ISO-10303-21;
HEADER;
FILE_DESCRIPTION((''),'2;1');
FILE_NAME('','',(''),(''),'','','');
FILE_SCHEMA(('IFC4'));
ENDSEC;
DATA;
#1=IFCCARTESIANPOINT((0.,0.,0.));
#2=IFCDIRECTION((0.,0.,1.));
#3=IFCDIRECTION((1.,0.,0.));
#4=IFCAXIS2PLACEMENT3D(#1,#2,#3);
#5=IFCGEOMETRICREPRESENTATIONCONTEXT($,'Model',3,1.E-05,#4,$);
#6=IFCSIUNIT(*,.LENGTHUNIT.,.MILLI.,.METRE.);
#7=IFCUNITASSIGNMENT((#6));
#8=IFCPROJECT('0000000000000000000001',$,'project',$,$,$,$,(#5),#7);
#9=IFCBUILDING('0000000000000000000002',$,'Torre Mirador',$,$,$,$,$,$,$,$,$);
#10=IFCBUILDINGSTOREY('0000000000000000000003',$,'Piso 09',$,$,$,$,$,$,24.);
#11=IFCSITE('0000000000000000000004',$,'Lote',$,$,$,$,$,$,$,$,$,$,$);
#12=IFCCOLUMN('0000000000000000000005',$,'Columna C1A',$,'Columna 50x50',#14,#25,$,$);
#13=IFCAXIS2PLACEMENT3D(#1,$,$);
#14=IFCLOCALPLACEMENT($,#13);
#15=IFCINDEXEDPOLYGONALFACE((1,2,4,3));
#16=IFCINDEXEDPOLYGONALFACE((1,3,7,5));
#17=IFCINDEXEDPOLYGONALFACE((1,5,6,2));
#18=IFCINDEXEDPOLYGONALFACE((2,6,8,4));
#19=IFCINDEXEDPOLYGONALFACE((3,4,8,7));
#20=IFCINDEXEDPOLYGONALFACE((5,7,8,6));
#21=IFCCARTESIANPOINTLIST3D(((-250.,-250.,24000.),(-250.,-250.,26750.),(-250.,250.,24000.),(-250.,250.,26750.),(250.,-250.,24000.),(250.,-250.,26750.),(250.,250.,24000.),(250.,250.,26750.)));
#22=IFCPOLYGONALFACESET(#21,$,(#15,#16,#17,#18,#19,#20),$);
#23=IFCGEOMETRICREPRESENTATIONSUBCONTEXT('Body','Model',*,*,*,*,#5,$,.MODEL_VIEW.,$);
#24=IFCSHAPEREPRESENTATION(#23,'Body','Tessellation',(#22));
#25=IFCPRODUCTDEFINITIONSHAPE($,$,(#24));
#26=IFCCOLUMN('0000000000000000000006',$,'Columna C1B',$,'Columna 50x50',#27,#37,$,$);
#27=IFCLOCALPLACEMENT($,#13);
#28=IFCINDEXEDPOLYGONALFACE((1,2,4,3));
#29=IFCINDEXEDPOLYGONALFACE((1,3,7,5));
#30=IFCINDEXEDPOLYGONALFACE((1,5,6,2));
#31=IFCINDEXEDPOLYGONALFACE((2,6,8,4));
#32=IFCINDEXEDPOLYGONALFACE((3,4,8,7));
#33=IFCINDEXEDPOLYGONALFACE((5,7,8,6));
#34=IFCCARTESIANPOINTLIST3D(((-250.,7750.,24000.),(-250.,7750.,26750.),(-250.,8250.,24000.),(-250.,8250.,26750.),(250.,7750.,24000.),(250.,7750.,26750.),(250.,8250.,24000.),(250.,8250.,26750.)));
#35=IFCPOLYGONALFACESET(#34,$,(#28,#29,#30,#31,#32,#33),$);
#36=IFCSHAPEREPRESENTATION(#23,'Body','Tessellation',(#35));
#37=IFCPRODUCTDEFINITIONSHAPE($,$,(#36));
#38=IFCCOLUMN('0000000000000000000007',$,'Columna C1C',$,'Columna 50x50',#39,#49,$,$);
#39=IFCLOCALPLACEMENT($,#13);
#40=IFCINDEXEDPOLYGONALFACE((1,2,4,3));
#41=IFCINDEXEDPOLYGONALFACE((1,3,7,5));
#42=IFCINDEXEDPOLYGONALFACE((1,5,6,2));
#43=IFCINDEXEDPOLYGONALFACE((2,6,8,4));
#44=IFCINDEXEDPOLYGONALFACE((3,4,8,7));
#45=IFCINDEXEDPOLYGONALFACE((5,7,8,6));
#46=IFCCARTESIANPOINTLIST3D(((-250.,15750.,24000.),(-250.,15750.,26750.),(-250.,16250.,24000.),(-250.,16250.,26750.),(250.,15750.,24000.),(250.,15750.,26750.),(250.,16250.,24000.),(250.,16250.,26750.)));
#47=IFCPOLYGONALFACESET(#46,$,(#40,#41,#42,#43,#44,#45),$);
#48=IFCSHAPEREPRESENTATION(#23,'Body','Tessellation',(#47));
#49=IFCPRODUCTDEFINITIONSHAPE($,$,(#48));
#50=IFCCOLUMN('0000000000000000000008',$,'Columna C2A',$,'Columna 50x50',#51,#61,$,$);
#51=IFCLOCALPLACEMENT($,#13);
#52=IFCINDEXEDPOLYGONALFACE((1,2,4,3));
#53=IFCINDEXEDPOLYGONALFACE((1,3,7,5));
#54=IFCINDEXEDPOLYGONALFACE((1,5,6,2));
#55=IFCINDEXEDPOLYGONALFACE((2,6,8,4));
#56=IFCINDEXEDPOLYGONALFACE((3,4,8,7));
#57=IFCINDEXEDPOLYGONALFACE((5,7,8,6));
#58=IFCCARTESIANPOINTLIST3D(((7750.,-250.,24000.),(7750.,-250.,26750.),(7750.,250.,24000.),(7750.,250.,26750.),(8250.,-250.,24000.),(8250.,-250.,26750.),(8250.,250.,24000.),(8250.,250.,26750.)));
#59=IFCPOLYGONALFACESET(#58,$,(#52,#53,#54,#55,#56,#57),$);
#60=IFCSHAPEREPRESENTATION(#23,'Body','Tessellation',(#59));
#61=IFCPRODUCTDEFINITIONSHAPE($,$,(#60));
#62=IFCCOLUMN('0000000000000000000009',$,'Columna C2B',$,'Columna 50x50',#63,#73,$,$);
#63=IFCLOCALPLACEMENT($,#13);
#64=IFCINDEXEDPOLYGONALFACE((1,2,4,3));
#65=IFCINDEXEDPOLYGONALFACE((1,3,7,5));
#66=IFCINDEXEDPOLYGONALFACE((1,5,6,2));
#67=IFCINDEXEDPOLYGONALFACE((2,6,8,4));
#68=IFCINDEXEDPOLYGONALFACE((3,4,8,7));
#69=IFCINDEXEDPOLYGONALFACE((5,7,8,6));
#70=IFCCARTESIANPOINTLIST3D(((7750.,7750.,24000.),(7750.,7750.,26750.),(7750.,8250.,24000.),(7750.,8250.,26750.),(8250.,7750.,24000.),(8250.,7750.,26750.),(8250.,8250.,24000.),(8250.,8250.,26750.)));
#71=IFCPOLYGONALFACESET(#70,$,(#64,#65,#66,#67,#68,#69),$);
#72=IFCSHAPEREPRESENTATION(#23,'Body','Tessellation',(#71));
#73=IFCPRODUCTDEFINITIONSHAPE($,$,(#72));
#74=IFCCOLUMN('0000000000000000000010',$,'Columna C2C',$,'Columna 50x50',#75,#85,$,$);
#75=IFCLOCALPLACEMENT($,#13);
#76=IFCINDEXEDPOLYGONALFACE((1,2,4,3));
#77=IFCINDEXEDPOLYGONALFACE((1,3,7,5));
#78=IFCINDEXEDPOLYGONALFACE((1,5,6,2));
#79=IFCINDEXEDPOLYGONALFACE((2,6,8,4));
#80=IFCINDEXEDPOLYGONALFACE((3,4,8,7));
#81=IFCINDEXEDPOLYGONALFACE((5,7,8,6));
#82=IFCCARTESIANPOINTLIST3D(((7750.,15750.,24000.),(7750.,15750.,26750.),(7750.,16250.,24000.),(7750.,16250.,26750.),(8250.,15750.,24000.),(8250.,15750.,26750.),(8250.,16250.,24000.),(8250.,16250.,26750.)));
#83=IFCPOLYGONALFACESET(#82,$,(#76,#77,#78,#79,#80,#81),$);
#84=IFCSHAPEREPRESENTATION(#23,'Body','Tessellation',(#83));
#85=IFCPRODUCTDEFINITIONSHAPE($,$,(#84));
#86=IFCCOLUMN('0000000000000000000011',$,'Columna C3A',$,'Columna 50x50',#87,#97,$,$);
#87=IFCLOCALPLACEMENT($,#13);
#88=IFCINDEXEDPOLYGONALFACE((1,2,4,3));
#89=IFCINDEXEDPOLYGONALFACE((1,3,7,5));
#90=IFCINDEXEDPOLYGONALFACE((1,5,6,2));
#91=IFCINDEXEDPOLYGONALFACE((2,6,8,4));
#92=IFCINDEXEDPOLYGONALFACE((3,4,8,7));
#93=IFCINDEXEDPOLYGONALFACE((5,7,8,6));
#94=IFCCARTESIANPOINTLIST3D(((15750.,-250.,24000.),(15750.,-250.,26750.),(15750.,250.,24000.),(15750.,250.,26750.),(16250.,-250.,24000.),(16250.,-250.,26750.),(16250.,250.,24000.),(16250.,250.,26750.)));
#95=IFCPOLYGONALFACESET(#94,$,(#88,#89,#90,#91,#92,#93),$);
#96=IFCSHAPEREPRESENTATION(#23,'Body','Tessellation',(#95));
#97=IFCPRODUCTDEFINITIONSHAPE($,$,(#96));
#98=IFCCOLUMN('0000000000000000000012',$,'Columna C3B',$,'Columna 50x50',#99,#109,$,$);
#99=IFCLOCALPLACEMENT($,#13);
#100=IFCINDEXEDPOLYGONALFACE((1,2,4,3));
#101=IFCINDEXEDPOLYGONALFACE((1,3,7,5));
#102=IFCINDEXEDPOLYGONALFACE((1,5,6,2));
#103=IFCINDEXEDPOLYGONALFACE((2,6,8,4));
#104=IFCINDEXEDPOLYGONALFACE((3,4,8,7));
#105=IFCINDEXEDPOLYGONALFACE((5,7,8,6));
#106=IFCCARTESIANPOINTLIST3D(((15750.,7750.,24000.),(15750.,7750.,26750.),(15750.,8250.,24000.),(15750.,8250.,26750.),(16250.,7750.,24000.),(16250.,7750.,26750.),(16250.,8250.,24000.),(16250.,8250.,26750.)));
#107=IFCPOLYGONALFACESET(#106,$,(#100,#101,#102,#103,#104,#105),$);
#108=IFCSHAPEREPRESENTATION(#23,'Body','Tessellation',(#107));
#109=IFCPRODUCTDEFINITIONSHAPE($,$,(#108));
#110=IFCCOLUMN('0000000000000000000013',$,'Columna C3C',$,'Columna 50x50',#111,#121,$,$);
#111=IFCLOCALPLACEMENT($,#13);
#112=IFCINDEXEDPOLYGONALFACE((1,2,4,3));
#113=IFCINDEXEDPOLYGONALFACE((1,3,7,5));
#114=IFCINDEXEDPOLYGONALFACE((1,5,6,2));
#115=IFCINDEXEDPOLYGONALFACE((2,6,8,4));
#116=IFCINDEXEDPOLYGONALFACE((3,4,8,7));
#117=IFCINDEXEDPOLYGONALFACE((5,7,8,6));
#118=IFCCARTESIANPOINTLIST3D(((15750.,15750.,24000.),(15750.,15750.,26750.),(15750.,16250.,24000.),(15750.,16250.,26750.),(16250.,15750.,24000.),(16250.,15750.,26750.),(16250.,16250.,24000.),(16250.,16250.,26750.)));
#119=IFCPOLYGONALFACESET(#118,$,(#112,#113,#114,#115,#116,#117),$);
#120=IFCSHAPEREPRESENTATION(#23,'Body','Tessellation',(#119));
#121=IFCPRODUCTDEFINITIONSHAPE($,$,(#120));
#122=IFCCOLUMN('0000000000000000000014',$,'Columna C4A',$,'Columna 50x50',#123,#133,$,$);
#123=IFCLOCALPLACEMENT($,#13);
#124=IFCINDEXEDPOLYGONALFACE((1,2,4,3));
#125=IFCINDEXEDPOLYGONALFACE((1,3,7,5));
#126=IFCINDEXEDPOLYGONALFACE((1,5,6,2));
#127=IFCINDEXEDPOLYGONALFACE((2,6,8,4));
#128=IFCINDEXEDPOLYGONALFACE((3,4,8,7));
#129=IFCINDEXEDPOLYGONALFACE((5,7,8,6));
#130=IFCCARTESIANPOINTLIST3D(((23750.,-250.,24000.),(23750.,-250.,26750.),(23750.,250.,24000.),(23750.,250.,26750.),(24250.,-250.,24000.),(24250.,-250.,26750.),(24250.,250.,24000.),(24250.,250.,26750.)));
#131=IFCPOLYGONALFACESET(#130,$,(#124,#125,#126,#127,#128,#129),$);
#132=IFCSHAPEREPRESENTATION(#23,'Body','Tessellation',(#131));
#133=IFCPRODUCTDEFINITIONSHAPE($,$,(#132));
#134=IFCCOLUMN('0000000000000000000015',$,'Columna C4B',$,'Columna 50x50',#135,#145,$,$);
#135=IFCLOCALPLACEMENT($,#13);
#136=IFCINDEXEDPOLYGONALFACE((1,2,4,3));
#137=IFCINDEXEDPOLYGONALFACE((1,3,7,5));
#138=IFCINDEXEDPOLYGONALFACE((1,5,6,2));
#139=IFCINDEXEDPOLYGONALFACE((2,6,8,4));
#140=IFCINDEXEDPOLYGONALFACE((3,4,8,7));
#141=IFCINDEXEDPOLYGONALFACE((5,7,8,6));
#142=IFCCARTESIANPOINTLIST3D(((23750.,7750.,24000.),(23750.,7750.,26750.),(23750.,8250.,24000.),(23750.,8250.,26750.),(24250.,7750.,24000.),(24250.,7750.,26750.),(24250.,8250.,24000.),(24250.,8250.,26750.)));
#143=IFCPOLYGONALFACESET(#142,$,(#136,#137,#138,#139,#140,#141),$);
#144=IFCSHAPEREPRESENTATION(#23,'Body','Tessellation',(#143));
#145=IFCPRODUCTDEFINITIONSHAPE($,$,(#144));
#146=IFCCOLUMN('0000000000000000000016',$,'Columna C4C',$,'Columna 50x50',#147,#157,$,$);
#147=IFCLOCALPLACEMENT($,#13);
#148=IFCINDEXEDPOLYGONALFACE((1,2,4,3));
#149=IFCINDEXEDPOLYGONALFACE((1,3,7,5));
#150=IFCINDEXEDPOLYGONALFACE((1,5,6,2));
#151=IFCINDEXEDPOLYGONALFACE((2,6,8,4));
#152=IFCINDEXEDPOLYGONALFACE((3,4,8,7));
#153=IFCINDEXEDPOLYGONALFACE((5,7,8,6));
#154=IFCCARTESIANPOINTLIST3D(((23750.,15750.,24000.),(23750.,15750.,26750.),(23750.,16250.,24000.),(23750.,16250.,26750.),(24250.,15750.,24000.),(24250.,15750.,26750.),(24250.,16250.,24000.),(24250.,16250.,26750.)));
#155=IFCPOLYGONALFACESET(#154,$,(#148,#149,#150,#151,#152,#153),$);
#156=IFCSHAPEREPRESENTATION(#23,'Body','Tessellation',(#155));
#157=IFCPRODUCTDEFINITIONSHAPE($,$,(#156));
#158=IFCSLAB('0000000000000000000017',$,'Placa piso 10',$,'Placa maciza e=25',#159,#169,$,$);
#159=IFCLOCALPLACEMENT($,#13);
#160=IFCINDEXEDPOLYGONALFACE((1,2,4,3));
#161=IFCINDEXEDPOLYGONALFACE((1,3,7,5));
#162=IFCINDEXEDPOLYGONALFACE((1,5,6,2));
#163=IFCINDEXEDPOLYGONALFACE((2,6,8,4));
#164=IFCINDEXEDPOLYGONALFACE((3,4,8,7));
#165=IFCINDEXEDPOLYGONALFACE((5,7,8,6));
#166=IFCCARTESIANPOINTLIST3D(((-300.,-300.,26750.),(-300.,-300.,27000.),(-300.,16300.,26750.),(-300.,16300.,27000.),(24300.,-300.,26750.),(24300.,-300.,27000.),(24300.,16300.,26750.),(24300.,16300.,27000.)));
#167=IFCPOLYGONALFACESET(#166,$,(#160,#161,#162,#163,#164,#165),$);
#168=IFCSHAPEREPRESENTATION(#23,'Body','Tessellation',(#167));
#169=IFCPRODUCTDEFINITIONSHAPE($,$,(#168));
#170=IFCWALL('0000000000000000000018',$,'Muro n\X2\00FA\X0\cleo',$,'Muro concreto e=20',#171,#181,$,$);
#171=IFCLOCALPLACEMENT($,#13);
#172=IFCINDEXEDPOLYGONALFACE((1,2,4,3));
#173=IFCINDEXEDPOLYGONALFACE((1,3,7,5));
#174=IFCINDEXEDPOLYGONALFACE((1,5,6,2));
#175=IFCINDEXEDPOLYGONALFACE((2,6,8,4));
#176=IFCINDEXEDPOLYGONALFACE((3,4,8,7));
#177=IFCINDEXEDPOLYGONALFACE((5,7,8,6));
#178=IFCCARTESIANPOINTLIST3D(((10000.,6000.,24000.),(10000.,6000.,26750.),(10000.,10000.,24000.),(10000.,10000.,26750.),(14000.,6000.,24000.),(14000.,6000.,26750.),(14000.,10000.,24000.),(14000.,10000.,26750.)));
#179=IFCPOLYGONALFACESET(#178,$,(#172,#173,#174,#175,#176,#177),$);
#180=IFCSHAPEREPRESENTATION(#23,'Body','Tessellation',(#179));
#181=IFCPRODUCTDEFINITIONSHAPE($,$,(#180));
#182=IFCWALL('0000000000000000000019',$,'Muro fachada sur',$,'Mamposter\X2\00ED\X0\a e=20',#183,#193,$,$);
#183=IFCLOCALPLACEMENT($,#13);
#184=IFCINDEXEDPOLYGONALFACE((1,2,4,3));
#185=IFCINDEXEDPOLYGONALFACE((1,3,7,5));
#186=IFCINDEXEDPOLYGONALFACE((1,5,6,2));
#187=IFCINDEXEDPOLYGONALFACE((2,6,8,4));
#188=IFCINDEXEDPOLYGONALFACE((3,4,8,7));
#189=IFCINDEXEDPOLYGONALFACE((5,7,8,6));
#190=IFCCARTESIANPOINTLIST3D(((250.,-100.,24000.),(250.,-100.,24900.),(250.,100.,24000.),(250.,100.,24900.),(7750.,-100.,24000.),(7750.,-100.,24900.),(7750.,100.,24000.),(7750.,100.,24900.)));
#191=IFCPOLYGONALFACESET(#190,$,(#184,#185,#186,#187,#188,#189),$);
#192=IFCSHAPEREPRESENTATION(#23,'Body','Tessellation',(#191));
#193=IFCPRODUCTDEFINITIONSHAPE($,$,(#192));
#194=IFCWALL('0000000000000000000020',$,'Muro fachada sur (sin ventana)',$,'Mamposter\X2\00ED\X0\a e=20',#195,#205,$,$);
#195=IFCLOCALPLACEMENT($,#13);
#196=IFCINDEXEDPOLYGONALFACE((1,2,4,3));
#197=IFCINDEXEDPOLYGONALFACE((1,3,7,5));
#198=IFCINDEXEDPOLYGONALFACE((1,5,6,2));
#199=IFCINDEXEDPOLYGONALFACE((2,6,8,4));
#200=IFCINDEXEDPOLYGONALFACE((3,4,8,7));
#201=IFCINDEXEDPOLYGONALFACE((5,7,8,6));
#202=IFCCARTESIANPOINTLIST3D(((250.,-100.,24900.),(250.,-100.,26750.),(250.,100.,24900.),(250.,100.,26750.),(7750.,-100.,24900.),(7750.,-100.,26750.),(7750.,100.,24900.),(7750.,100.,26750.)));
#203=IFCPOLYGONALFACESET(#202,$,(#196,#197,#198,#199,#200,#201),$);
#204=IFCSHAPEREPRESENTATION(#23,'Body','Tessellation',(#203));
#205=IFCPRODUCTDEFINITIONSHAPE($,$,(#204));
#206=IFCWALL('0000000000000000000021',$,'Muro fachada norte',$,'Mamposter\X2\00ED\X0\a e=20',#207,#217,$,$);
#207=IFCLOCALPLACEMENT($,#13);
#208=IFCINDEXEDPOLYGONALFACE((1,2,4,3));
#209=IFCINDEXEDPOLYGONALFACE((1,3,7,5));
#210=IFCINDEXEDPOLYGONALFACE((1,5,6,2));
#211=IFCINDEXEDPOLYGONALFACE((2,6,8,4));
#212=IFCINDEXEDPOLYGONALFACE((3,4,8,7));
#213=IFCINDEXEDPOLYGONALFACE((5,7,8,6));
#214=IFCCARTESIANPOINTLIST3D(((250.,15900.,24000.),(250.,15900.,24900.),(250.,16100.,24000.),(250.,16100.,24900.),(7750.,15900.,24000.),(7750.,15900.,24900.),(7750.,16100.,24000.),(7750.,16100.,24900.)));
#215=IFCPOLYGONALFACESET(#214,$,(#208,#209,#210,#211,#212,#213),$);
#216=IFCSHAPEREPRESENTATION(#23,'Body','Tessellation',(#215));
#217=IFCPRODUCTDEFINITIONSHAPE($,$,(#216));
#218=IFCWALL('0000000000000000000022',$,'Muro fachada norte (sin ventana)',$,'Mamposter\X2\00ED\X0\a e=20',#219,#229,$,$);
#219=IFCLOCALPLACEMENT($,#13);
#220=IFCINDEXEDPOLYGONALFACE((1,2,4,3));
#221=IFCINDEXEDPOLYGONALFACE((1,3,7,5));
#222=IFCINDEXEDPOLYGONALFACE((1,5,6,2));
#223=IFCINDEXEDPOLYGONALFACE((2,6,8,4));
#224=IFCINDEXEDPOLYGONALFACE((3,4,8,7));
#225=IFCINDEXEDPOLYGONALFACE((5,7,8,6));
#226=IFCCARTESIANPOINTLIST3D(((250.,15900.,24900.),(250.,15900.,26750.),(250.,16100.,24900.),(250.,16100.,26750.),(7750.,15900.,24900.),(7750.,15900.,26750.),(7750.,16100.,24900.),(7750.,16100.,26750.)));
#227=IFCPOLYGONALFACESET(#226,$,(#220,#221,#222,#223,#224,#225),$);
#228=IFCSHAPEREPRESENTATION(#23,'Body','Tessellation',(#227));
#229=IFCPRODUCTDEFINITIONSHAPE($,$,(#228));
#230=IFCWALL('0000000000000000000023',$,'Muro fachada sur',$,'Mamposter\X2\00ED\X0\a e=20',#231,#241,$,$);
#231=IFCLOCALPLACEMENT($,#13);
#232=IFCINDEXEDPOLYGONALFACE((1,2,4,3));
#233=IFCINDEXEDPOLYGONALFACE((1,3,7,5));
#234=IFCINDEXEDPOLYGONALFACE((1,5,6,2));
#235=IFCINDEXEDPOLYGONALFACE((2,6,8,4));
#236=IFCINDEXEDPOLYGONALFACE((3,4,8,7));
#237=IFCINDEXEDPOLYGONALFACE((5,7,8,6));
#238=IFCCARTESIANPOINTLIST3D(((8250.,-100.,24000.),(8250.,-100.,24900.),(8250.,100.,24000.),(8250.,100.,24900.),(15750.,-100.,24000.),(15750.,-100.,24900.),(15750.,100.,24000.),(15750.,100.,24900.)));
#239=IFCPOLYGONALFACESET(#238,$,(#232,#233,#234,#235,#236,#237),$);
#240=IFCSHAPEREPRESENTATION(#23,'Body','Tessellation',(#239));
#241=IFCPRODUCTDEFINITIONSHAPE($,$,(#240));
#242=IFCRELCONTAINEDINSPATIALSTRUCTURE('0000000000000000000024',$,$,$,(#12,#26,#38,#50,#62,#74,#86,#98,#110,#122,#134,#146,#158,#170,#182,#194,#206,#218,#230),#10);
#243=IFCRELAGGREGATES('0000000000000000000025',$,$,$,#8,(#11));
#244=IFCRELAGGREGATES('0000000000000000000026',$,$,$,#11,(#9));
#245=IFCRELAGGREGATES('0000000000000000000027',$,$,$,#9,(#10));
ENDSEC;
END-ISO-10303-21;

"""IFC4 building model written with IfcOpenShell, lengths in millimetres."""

from ifc_helpers import new_model, si_unit, frame, origin_with_axes, place, context, subcontext, project, spatial, indexed_curve, outline, extrude, element, save


model = new_model("IFC4")

# Units and contexts
model_context = context("Model", 3, precision=1e-05, world=origin_with_axes())
body_context = subcontext(model_context, "Body", "Model", "MODEL_VIEW")
ifc_project = project(units=[si_unit("LENGTHUNIT", "METRE", prefix="MILLI")], contexts=[model_context])

# Site, building, storey
site = spatial("IfcSite", under=ifc_project, Name="Lote")
building = spatial("IfcBuilding", under=site, Name="Torre Mirador")
storey = spatial("IfcBuildingStorey", under=building, Name="Piso 09", Elevation=24.0)

# Columns
for number, where, z_axis, x_axis, name in (
    (1, (-250.0, -250.0, 24000.0), (0.0, 0.0, 1.0), (1.0, 0.0, 0.0), "Columna C1A"),
    (2, (-250.0, 7750.0, 24000.0), (0.0, 0.0, 1.0), (1.0, 0.0, 0.0), "Columna C1B"),
    (3, (-250.0, 15750.0, 24000.0), (0.0, 0.0, 1.0), (1.0, 0.0, 0.0), "Columna C1C"),
    (4, (7750.0, -250.0, 24000.0), (0.0, 0.0, 1.0), (1.0, 0.0, 0.0), "Columna C2A"),
    (5, (7750.0, 7750.0, 24000.0), (0.0, 0.0, 1.0), (1.0, 0.0, 0.0), "Columna C2B"),
    (6, (7750.0, 15750.0, 24000.0), (0.0, 0.0, 1.0), (1.0, 0.0, 0.0), "Columna C2C"),
    (7, (15750.0, -250.0, 24000.0), (0.0, 0.0, 1.0), (1.0, 0.0, 0.0), "Columna C3A"),
    (8, (15750.0, 7750.0, 24000.0), (0.0, 0.0, 1.0), (1.0, 0.0, 0.0), "Columna C3B"),
    (9, (15750.0, 15750.0, 24000.0), (0.0, 0.0, 1.0), (1.0, 0.0, 0.0), "Columna C3C"),
    (10, (23750.0, -250.0, 24000.0), (0.0, 0.0, 1.0), (1.0, 0.0, 0.0), "Columna C4A"),
    (11, (23750.0, 7750.0, 24000.0), (0.0, 0.0, 1.0), (1.0, 0.0, 0.0), "Columna C4B"),
    (12, (23750.0, 15750.0, 24000.0), (0.0, 0.0, 1.0), (1.0, 0.0, 0.0), "Columna C4C"),
):
    element("IfcColumn", number, at=place(None, frame(where, z_axis=z_axis, x_axis=x_axis)), inside=storey, Name=name, ObjectType="Columna 50x50", context=body_context, shape_type="SweptSolid", body=[
        extrude(outline(indexed_curve([(0.0, 0.0), (0.0, 500.0), (500.0, 500.0), (500.0, 0.0), (0.0, 0.0)], self_intersect=False)), origin_with_axes(), (0.0, 0.0, 1.0), 2750.0),
    ])

# Slab
slab_placement = place(None, frame((-300.0, -300.0, 26750.0), z_axis=(0.0, 0.0, 1.0), x_axis=(1.0, 0.0, 0.0)))
element("IfcSlab", 13, at=slab_placement, inside=storey, Name="Placa piso 10", ObjectType="Placa maciza e=25", context=body_context, shape_type="SweptSolid", body=[
    extrude(outline(indexed_curve([(0.0, 0.0), (0.0, 16600.0), (24600.0, 16600.0), (24600.0, 0.0), (0.0, 0.0)], self_intersect=False)), origin_with_axes(), (0.0, 0.0, 1.0), 250.0),
])

# Walls
wall_1_placement = place(None, frame((10000.0, 6000.0, 24000.0), z_axis=(0.0, 0.0, 1.0), x_axis=(1.0, 0.0, 0.0)))
element("IfcWall", 14, at=wall_1_placement, inside=storey, Name="Muro núcleo", ObjectType="Muro concreto e=20", context=body_context, shape_type="SweptSolid", body=[
    extrude(outline(indexed_curve([(0.0, 0.0), (0.0, 4000.0), (4000.0, 4000.0), (4000.0, 0.0), (0.0, 0.0)], self_intersect=False)), origin_with_axes(), (0.0, 0.0, 1.0), 2750.0),
])
wall_2_placement = place(None, frame((250.0, -100.0, 24000.0), z_axis=(0.0, 0.0, 1.0), x_axis=(1.0, 0.0, 0.0)))
element("IfcWall", 15, at=wall_2_placement, inside=storey, Name="Muro fachada sur", ObjectType="Mampostería e=20", context=body_context, shape_type="SweptSolid", body=[
    extrude(outline(indexed_curve([(0.0, 0.0), (0.0, 200.0), (7500.0, 200.0), (7500.0, 0.0), (0.0, 0.0)], self_intersect=False)), origin_with_axes(), (0.0, 0.0, 1.0), 900.0),
])
wall_3_placement = place(None, frame((250.0, -100.0, 24900.0), z_axis=(0.0, 0.0, 1.0), x_axis=(1.0, 0.0, 0.0)))
element("IfcWall", 16, at=wall_3_placement, inside=storey, Name="Muro fachada sur (sin ventana)", ObjectType="Mampostería e=20", context=body_context, shape_type="SweptSolid", body=[
    extrude(outline(indexed_curve([(0.0, 0.0), (0.0, 200.0), (7500.0, 200.0), (7500.0, 0.0), (0.0, 0.0)], self_intersect=False)), origin_with_axes(), (0.0, 0.0, 1.0), 1850.0),
])
wall_4_placement = place(None, frame((250.0, 15900.0, 24000.0), z_axis=(0.0, 0.0, 1.0), x_axis=(1.0, 0.0, 0.0)))
element("IfcWall", 17, at=wall_4_placement, inside=storey, Name="Muro fachada norte", ObjectType="Mampostería e=20", context=body_context, shape_type="SweptSolid", body=[
    extrude(outline(indexed_curve([(0.0, 0.0), (0.0, 200.0), (7500.0, 200.0), (7500.0, 0.0), (0.0, 0.0)], self_intersect=False)), origin_with_axes(), (0.0, 0.0, 1.0), 900.0),
])
wall_5_placement = place(None, frame((250.0, 15900.0, 24900.0), z_axis=(0.0, 0.0, 1.0), x_axis=(1.0, 0.0, 0.0)))
element("IfcWall", 18, at=wall_5_placement, inside=storey, Name="Muro fachada norte (sin ventana)", ObjectType="Mampostería e=20", context=body_context, shape_type="SweptSolid", body=[
    extrude(outline(indexed_curve([(0.0, 0.0), (0.0, 200.0), (7500.0, 200.0), (7500.0, 0.0), (0.0, 0.0)], self_intersect=False)), origin_with_axes(), (0.0, 0.0, 1.0), 1850.0),
])
wall_6_placement = place(None, frame((8250.0, -100.0, 24000.0), z_axis=(0.0, 0.0, 1.0), x_axis=(1.0, 0.0, 0.0)))
element("IfcWall", 19, at=wall_6_placement, inside=storey, Name="Muro fachada sur", ObjectType="Mampostería e=20", context=body_context, shape_type="SweptSolid", body=[
    extrude(outline(indexed_curve([(0.0, 0.0), (0.0, 200.0), (7500.0, 200.0), (7500.0, 0.0), (0.0, 0.0)], self_intersect=False)), origin_with_axes(), (0.0, 0.0, 1.0), 900.0),
])

save(model, "model.ifc")
